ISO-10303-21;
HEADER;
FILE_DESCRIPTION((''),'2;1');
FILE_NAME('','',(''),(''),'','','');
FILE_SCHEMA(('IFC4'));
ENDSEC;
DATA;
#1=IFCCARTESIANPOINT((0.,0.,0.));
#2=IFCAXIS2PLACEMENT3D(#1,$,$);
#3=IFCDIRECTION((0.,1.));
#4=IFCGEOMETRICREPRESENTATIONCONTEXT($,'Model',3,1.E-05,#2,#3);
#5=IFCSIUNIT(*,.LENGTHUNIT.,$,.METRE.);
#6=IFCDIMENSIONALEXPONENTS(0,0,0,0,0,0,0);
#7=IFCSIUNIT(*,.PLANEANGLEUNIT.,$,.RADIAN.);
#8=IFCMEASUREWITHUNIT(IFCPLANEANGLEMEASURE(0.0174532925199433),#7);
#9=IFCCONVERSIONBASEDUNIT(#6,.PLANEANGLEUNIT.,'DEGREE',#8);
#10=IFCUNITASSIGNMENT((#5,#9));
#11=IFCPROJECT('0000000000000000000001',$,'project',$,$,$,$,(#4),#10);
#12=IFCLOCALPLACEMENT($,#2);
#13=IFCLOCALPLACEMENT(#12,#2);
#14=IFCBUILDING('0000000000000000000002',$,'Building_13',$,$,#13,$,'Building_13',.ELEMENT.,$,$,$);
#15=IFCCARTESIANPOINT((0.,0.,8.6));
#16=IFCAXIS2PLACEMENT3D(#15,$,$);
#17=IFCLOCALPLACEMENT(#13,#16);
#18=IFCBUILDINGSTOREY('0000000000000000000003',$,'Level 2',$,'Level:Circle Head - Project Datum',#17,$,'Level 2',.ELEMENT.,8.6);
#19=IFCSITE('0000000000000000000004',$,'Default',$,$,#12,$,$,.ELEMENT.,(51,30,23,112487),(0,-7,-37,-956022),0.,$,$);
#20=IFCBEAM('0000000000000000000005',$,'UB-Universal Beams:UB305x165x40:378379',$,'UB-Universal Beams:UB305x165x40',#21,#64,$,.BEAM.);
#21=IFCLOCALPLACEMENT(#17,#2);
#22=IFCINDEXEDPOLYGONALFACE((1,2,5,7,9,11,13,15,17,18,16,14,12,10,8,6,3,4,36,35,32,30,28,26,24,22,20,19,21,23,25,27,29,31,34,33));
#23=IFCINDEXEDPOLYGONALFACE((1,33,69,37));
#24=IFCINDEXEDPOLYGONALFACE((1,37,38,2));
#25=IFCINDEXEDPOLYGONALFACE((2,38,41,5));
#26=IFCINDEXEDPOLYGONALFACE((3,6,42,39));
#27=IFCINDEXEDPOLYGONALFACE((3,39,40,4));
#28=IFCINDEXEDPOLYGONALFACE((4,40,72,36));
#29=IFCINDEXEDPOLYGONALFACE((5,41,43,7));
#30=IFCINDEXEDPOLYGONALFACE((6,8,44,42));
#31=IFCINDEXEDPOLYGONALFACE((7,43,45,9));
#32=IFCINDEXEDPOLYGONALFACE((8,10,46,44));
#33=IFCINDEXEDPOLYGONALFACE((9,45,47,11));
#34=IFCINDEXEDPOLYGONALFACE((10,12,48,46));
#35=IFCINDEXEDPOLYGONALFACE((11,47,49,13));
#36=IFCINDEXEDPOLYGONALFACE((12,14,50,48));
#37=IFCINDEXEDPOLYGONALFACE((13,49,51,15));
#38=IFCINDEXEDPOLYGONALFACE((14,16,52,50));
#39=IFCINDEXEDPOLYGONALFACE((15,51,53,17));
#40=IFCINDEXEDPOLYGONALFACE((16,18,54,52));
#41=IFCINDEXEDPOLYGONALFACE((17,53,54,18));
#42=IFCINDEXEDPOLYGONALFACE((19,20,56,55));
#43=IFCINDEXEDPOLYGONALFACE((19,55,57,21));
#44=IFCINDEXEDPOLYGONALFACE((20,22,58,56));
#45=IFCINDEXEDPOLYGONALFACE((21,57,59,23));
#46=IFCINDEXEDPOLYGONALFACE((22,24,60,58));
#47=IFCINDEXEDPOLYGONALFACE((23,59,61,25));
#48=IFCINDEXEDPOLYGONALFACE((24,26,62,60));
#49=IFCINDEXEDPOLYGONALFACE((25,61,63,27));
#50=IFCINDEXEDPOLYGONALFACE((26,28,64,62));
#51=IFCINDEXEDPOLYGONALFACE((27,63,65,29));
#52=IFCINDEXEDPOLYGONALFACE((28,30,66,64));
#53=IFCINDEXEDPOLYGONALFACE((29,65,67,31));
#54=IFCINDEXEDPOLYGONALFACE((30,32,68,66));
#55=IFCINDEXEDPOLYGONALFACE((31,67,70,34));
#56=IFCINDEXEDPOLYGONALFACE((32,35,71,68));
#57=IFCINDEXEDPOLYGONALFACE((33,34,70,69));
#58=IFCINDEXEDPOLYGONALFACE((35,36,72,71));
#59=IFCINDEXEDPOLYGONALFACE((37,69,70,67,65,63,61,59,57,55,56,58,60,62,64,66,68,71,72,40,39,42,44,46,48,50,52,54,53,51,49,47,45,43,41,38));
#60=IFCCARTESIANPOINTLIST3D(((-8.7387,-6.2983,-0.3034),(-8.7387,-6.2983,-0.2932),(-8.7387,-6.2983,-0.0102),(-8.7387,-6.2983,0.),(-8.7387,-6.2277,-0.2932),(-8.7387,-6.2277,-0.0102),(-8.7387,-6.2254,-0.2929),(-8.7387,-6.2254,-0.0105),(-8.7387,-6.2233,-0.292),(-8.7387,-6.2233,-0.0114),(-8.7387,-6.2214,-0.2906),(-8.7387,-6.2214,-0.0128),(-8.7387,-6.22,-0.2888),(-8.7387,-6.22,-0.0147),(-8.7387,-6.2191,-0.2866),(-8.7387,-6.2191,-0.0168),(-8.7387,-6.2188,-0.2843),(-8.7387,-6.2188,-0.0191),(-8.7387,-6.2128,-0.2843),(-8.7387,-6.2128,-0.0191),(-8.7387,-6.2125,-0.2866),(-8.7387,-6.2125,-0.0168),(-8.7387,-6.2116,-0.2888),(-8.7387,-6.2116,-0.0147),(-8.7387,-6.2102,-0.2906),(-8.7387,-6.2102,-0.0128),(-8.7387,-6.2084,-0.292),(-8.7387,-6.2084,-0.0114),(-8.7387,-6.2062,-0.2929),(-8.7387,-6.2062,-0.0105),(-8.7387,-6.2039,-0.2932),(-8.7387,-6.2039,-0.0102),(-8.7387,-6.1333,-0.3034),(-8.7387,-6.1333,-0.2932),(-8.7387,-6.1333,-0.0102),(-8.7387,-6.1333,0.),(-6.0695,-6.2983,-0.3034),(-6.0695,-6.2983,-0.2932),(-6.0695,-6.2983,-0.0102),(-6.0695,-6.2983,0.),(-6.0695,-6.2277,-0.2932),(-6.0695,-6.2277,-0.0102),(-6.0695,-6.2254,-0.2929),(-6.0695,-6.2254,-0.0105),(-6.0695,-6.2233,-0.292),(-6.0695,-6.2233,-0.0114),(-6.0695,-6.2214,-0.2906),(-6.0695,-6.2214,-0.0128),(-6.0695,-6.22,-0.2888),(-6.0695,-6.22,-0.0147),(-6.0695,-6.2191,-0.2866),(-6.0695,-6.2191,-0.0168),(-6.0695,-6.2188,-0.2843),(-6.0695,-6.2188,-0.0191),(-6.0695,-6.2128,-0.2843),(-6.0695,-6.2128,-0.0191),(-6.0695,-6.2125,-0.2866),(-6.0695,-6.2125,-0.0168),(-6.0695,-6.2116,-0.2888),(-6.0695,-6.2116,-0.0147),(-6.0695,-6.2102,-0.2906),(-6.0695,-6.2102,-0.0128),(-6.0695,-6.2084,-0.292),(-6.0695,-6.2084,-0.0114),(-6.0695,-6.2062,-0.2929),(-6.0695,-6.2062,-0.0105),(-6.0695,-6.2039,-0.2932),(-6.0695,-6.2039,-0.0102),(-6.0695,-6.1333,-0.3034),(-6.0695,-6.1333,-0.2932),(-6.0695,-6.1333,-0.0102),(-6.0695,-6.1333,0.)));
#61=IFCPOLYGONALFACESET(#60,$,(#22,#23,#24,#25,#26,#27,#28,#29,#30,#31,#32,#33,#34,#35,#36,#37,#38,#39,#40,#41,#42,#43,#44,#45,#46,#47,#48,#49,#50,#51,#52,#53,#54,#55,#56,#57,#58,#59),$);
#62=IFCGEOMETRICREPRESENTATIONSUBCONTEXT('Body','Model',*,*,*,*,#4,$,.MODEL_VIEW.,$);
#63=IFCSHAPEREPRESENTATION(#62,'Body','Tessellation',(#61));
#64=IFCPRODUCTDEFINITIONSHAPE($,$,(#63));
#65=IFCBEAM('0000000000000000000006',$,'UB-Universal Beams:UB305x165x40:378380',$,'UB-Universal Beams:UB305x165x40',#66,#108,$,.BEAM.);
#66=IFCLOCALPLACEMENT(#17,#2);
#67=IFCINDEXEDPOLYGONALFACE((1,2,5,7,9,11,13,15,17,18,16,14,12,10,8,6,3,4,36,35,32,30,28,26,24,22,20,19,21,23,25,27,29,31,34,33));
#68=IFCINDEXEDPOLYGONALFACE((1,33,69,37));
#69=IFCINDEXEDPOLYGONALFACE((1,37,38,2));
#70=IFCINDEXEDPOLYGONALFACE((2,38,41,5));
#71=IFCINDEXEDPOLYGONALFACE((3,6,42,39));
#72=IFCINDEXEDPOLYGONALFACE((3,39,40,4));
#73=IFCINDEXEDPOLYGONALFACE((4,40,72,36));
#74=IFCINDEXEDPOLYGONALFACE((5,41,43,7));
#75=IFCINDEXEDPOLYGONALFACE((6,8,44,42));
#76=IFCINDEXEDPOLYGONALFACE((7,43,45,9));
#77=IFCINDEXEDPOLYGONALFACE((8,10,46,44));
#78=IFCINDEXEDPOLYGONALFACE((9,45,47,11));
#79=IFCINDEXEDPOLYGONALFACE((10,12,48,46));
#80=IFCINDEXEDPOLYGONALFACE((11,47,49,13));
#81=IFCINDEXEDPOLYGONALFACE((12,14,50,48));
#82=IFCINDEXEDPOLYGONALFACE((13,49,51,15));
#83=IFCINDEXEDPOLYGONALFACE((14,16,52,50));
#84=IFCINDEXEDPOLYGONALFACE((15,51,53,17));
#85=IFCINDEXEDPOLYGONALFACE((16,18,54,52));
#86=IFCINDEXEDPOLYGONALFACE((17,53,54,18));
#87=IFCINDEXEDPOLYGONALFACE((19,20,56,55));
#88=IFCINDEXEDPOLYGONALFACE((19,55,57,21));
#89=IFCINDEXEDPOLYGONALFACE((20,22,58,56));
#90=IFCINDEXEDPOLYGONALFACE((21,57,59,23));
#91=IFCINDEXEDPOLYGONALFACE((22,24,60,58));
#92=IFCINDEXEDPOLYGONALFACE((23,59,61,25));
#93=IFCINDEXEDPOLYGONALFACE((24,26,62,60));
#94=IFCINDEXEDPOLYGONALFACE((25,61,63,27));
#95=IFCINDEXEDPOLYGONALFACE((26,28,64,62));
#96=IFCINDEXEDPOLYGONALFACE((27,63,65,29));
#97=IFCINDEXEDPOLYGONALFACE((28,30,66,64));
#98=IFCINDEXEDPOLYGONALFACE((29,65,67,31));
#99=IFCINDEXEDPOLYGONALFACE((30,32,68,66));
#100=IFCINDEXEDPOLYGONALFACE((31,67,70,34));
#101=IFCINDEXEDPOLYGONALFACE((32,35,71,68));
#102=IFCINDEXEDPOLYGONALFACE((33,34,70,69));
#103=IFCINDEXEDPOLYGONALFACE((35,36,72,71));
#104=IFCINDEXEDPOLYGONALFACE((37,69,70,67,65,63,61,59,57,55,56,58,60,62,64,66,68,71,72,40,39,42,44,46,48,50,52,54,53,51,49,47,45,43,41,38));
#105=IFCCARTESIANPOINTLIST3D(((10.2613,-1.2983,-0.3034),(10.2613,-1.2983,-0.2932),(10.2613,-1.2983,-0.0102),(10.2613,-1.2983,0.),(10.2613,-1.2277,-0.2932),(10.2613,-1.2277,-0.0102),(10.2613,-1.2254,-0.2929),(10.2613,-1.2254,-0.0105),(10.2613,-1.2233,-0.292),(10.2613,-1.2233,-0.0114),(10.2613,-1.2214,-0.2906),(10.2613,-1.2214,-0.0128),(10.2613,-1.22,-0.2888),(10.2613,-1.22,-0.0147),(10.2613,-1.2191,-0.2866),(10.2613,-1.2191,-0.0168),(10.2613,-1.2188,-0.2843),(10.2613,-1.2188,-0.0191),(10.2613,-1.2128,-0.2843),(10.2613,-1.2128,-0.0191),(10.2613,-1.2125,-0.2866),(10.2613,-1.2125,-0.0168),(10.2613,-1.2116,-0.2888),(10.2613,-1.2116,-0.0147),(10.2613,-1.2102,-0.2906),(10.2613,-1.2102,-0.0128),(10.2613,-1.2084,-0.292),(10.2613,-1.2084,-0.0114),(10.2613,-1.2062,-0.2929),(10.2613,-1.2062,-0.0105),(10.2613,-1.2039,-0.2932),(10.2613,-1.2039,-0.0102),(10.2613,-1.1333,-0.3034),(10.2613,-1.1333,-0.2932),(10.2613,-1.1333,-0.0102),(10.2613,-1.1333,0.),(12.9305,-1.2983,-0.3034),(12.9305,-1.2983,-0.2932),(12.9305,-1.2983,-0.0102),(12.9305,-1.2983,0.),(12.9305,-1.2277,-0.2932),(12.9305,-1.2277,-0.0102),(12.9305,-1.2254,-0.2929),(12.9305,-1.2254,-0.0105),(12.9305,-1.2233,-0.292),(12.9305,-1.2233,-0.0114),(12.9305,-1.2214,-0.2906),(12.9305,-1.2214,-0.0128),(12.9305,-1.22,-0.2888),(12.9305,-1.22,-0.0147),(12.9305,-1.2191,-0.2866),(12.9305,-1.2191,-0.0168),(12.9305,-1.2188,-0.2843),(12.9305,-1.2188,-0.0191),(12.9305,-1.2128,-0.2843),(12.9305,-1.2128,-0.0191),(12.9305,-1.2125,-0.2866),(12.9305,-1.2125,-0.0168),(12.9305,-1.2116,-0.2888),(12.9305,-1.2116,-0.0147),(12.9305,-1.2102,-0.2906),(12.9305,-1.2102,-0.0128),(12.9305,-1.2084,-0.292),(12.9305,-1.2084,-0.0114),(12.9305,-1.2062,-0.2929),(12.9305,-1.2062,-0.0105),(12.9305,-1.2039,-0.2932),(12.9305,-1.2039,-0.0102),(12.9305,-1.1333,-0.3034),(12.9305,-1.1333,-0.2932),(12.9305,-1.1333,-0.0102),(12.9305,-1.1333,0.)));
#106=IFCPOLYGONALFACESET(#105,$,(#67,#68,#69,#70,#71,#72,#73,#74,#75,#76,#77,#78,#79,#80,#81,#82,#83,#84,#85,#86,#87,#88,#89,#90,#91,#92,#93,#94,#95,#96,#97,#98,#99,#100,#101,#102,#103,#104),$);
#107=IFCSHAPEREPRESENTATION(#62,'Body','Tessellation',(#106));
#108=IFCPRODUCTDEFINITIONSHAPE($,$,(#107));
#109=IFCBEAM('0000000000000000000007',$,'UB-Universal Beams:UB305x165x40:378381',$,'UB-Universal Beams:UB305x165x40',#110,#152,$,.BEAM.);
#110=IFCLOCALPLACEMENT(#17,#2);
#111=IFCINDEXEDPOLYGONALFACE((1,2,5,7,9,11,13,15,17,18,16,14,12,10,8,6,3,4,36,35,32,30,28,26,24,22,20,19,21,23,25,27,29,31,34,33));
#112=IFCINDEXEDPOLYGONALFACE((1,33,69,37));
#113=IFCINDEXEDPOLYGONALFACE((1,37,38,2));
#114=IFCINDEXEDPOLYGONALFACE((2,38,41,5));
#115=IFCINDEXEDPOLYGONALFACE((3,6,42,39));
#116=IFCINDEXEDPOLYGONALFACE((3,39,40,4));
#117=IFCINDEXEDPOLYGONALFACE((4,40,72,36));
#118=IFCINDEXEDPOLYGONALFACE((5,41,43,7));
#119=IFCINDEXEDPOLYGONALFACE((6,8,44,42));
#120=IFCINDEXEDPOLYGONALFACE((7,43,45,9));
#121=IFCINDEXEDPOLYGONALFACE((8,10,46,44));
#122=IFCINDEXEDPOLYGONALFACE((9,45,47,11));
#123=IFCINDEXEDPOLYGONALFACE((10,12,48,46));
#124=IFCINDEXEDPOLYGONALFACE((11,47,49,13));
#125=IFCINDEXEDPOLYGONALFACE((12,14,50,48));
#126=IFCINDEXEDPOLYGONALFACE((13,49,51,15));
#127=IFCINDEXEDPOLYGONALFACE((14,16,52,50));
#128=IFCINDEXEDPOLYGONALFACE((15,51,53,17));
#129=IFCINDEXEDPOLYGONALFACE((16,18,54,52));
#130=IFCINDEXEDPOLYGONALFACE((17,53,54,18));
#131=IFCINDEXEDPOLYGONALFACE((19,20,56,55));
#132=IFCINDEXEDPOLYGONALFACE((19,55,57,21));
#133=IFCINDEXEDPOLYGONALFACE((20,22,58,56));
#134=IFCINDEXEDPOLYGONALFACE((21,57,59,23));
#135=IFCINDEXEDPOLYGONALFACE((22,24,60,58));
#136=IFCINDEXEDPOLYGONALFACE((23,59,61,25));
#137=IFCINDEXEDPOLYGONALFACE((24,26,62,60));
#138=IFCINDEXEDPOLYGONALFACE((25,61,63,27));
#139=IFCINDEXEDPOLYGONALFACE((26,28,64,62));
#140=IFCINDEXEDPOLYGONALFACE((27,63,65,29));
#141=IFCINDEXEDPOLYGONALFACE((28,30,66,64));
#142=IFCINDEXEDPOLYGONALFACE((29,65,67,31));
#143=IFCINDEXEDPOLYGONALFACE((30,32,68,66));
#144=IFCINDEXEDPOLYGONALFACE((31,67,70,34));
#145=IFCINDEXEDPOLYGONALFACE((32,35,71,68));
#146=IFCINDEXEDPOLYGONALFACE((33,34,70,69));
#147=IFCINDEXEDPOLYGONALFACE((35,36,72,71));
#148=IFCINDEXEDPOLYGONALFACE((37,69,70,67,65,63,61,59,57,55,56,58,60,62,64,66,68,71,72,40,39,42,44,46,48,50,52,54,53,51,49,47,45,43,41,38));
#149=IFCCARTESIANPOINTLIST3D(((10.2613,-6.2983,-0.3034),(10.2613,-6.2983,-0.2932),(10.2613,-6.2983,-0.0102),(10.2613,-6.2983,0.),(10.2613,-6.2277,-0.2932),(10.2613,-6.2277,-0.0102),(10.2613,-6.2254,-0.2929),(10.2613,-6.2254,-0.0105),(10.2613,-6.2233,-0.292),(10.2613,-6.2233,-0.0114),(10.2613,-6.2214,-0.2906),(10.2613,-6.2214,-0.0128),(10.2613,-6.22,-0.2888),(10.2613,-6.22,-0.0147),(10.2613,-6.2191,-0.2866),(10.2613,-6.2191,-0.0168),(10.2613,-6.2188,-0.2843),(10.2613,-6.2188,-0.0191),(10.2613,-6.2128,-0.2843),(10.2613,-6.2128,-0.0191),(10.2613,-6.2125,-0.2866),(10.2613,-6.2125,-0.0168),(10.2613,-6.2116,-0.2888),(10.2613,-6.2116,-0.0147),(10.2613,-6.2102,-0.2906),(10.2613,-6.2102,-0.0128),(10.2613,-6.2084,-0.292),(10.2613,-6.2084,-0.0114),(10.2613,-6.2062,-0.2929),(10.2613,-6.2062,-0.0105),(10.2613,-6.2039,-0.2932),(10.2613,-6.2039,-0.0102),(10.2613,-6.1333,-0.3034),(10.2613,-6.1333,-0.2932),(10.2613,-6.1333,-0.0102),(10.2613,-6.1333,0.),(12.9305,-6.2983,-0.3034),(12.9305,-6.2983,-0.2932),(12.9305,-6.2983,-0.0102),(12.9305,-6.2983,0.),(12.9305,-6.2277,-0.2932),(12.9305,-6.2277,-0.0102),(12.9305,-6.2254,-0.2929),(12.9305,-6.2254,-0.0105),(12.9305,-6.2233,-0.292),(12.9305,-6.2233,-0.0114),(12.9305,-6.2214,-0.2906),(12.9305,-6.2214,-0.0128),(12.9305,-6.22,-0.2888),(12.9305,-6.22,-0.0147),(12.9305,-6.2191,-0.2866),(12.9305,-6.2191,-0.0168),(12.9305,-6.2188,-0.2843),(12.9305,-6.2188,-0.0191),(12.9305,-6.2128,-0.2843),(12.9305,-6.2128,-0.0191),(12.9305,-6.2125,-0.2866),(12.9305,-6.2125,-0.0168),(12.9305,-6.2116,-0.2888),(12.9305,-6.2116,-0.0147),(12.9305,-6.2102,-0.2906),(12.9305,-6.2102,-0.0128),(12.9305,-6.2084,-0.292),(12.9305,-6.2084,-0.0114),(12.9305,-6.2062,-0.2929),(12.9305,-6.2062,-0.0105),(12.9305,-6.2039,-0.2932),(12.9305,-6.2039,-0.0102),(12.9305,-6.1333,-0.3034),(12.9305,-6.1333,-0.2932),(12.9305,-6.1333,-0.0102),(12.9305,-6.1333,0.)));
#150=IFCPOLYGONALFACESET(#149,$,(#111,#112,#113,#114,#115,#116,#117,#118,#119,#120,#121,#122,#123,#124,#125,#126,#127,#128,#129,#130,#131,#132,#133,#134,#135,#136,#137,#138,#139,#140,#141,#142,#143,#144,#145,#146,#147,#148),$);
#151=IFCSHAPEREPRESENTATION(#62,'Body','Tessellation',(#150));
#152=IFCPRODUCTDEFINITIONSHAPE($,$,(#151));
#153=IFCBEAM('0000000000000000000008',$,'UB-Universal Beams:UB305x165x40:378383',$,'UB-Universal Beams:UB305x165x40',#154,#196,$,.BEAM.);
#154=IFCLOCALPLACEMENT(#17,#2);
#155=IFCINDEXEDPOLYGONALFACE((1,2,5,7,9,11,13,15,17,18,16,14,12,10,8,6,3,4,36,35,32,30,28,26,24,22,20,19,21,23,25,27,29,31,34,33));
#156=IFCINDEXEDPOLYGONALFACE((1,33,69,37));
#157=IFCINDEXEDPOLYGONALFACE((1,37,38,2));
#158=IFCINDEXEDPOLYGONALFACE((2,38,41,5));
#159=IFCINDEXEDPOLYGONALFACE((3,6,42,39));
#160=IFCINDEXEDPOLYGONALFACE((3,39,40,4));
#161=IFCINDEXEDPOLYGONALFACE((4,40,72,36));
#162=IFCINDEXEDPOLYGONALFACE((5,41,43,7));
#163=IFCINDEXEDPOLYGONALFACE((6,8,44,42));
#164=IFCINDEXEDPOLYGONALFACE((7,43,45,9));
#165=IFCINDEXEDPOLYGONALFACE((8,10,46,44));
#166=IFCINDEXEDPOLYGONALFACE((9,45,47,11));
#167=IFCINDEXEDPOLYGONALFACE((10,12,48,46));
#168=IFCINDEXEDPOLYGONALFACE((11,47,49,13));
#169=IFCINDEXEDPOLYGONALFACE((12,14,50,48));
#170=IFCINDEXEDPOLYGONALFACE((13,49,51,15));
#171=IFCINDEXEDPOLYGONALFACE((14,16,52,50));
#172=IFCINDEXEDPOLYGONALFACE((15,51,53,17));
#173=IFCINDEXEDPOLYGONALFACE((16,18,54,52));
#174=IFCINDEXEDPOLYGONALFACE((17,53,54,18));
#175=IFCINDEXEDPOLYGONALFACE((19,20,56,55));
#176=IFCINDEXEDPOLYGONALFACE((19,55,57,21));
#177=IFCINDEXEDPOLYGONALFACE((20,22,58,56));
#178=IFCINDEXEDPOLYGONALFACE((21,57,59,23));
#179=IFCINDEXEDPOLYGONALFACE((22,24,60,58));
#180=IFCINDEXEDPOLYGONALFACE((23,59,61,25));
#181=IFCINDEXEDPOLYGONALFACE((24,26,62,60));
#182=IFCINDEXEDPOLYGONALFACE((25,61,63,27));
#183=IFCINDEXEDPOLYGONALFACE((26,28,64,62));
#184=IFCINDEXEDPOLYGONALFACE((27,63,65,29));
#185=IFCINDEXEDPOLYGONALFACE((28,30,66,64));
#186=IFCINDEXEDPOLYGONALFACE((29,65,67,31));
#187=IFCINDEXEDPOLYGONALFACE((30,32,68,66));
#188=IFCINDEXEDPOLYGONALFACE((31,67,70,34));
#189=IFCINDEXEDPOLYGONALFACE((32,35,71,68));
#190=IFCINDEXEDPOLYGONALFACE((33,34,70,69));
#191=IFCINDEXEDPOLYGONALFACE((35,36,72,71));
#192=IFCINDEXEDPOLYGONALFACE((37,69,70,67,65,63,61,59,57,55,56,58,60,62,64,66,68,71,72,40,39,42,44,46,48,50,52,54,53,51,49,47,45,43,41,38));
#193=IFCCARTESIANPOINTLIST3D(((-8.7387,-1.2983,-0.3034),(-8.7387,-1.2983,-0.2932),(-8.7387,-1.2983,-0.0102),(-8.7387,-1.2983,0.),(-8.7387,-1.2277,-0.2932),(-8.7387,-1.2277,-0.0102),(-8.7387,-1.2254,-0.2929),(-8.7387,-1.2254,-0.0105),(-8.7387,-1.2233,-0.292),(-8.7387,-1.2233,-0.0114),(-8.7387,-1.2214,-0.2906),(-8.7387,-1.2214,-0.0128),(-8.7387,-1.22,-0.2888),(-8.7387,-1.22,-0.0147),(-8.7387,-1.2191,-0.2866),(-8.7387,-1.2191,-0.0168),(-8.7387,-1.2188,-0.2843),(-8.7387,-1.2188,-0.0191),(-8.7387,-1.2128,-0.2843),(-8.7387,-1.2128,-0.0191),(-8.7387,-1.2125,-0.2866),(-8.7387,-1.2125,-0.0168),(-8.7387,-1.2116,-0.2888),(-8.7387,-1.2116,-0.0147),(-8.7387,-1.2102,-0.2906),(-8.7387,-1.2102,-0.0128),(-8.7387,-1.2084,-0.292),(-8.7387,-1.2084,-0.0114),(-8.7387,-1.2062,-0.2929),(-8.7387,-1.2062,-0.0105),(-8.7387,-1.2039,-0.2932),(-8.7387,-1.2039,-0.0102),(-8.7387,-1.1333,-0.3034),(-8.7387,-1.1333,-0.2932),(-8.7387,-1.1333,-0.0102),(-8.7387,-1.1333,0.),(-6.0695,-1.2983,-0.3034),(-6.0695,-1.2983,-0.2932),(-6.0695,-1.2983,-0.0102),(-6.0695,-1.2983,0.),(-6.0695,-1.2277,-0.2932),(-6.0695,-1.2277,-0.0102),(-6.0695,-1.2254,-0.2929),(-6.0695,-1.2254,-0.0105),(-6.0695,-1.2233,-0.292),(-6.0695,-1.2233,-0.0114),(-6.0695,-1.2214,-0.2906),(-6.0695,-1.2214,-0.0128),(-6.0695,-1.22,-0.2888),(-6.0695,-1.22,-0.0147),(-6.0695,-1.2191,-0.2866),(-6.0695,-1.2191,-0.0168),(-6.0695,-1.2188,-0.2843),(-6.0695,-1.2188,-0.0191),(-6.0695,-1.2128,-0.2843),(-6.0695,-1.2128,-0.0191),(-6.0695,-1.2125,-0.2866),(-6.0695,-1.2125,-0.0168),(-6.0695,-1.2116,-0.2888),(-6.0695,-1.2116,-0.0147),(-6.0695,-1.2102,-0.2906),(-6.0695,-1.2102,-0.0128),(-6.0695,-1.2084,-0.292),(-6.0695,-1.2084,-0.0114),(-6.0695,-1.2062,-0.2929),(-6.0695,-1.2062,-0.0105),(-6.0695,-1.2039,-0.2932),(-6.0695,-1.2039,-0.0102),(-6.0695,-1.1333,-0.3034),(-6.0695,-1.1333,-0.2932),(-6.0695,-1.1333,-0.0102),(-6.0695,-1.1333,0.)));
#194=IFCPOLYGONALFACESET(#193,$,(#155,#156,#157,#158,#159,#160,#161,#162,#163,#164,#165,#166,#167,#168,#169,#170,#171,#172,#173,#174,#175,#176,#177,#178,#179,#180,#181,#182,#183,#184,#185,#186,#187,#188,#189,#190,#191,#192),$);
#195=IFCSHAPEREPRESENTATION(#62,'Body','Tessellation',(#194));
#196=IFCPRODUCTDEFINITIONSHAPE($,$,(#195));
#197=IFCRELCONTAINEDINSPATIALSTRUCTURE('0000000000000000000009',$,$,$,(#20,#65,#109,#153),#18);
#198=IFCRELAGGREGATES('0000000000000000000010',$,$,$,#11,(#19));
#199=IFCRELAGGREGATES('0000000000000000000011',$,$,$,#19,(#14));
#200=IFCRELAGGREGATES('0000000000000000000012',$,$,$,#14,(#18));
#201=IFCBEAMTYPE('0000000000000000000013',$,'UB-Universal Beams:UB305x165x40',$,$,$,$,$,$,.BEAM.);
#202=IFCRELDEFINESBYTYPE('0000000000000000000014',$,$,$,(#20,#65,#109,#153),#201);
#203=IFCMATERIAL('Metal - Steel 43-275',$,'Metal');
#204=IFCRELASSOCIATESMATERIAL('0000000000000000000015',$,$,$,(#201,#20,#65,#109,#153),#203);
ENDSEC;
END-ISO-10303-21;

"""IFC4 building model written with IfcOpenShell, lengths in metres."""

from ifc_helpers import new_model, entity, si_unit, converted_unit, direction, frame, origin, place, context, subcontext, project, spatial, line, arc, indexed_curve, outline, extrude, source, transform, mapped, material, type_object, type_shapes, element, save


model = new_model("IFC4")

# Units and contexts
model_context = context("Model", 3, precision=1e-05, world=origin(), true_north=direction((0.0, 1.0)))
body_context = subcontext(model_context, "Body", "Model", "MODEL_VIEW")
ifc_project = project(units=[si_unit("LENGTHUNIT", "METRE"), converted_unit("PLANEANGLEUNIT", "DEGREE", entity("IfcPlaneAngleMeasure", 0.0174532925199433), si_unit("PLANEANGLEUNIT", "RADIAN"), dimensions=[0, 0, 0, 0, 0, 0, 0])], contexts=[model_context])

# Site, building, storey
site_placement = place(None, origin())
site = spatial("IfcSite", under=ifc_project, at=site_placement, Name="Default", CompositionType="ELEMENT", RefLatitude=(51, 30, 23, 112487), RefLongitude=(0, -7, -37, -956022), RefElevation=0.0)
building_placement = place(site_placement, origin())
building = spatial("IfcBuilding", under=site, at=building_placement, Name="Building_13", LongName="Building_13", CompositionType="ELEMENT")
storey_placement = place(building_placement, frame((0.0, 0.0, 8.6)))
storey = spatial("IfcBuildingStorey", under=building, at=storey_placement, Name="Level 2", ObjectType="Level:Circle Head - Project Datum", LongName="Level 2", CompositionType="ELEMENT", Elevation=8.6)

# Beams
ifc_material_1 = material(Name="Metal - Steel 43-275", Category="Metal")
beam_type_1 = type_object("IfcBeamType", Name="UB-Universal Beams:UB305x165x40", PredefinedType="BEAM", material=ifc_material_1)
shared_shape_1 = source(origin(), body_context, "Body", "SweptSolid", [
    extrude(outline(indexed_curve([(-0.0825, -0.1415), (-0.0825, -0.1517), (0.0825, -0.1517), (0.0825, -0.1415), (0.0119, -0.1415), (0.0056, -0.1389), (0.003, -0.1326), (0.003, 0.1326), (0.0056, 0.1389), (0.0119, 0.1415), (0.0825, 0.1415), (0.0825, 0.1517), (-0.0825, 0.1517), (-0.0825, 0.1415), (-0.0119, 0.1415), (-0.0056, 0.1389), (-0.003, 0.1326), (-0.003, -0.1326), (-0.0056, -0.1389), (-0.0119, -0.1415)], segments=[line(1, 2, 3, 4, 5), arc(5, 6, 7), line(7, 8), arc(8, 9, 10), line(10, 11, 12, 13, 14, 15), arc(15, 16, 17), line(17, 18), arc(18, 19, 20), line(20, 1)], self_intersect=False)), frame((-1.3346, 0.0, 0.0), z_axis=(-1.0, 0.0, 0.0), x_axis=(0.0, -1.0, 0.0)), (0.0, 0.0, -1.0), 2.6692),
])
type_shapes(beam_type_1, [shared_shape_1])
beam_1_placement = place(storey_placement, frame((-7.4041, -6.2158, -0.1517)))
element("IfcBeam", 1, at=beam_1_placement, inside=storey, type_object=beam_type_1, material=ifc_material_1, Name="UB-Universal Beams:UB305x165x40:378379", ObjectType="UB-Universal Beams:UB305x165x40", PredefinedType="BEAM", context=body_context, shape_type="MappedRepresentation", body=[
    mapped(shared_shape_1, transform((0.0, 0.0, 0.0), scale=1.0)),
])
beam_2_placement = place(storey_placement, frame((11.5959, -1.2158, -0.1517), z_axis=(0.0, 0.0, 1.0), x_axis=(-1.0, 0.0, 0.0)))
element("IfcBeam", 2, at=beam_2_placement, inside=storey, type_object=beam_type_1, material=ifc_material_1, Name="UB-Universal Beams:UB305x165x40:378380", ObjectType="UB-Universal Beams:UB305x165x40", PredefinedType="BEAM", context=body_context, shape_type="MappedRepresentation", body=[
    mapped(shared_shape_1, transform((0.0, 0.0, 0.0), scale=1.0)),
])
for number, where, name in (
    (3, (11.5959, -6.2158, -0.1517), "UB-Universal Beams:UB305x165x40:378381"),
    (4, (-7.4041, -1.2158, -0.1517), "UB-Universal Beams:UB305x165x40:378383"),
):
    element("IfcBeam", number, at=place(storey_placement, frame(where)), inside=storey, type_object=beam_type_1, material=ifc_material_1, Name=name, ObjectType="UB-Universal Beams:UB305x165x40", PredefinedType="BEAM", context=body_context, shape_type="MappedRepresentation", body=[
        mapped(shared_shape_1, transform((0.0, 0.0, 0.0), scale=1.0)),
    ])

save(model, "model.ifc")
